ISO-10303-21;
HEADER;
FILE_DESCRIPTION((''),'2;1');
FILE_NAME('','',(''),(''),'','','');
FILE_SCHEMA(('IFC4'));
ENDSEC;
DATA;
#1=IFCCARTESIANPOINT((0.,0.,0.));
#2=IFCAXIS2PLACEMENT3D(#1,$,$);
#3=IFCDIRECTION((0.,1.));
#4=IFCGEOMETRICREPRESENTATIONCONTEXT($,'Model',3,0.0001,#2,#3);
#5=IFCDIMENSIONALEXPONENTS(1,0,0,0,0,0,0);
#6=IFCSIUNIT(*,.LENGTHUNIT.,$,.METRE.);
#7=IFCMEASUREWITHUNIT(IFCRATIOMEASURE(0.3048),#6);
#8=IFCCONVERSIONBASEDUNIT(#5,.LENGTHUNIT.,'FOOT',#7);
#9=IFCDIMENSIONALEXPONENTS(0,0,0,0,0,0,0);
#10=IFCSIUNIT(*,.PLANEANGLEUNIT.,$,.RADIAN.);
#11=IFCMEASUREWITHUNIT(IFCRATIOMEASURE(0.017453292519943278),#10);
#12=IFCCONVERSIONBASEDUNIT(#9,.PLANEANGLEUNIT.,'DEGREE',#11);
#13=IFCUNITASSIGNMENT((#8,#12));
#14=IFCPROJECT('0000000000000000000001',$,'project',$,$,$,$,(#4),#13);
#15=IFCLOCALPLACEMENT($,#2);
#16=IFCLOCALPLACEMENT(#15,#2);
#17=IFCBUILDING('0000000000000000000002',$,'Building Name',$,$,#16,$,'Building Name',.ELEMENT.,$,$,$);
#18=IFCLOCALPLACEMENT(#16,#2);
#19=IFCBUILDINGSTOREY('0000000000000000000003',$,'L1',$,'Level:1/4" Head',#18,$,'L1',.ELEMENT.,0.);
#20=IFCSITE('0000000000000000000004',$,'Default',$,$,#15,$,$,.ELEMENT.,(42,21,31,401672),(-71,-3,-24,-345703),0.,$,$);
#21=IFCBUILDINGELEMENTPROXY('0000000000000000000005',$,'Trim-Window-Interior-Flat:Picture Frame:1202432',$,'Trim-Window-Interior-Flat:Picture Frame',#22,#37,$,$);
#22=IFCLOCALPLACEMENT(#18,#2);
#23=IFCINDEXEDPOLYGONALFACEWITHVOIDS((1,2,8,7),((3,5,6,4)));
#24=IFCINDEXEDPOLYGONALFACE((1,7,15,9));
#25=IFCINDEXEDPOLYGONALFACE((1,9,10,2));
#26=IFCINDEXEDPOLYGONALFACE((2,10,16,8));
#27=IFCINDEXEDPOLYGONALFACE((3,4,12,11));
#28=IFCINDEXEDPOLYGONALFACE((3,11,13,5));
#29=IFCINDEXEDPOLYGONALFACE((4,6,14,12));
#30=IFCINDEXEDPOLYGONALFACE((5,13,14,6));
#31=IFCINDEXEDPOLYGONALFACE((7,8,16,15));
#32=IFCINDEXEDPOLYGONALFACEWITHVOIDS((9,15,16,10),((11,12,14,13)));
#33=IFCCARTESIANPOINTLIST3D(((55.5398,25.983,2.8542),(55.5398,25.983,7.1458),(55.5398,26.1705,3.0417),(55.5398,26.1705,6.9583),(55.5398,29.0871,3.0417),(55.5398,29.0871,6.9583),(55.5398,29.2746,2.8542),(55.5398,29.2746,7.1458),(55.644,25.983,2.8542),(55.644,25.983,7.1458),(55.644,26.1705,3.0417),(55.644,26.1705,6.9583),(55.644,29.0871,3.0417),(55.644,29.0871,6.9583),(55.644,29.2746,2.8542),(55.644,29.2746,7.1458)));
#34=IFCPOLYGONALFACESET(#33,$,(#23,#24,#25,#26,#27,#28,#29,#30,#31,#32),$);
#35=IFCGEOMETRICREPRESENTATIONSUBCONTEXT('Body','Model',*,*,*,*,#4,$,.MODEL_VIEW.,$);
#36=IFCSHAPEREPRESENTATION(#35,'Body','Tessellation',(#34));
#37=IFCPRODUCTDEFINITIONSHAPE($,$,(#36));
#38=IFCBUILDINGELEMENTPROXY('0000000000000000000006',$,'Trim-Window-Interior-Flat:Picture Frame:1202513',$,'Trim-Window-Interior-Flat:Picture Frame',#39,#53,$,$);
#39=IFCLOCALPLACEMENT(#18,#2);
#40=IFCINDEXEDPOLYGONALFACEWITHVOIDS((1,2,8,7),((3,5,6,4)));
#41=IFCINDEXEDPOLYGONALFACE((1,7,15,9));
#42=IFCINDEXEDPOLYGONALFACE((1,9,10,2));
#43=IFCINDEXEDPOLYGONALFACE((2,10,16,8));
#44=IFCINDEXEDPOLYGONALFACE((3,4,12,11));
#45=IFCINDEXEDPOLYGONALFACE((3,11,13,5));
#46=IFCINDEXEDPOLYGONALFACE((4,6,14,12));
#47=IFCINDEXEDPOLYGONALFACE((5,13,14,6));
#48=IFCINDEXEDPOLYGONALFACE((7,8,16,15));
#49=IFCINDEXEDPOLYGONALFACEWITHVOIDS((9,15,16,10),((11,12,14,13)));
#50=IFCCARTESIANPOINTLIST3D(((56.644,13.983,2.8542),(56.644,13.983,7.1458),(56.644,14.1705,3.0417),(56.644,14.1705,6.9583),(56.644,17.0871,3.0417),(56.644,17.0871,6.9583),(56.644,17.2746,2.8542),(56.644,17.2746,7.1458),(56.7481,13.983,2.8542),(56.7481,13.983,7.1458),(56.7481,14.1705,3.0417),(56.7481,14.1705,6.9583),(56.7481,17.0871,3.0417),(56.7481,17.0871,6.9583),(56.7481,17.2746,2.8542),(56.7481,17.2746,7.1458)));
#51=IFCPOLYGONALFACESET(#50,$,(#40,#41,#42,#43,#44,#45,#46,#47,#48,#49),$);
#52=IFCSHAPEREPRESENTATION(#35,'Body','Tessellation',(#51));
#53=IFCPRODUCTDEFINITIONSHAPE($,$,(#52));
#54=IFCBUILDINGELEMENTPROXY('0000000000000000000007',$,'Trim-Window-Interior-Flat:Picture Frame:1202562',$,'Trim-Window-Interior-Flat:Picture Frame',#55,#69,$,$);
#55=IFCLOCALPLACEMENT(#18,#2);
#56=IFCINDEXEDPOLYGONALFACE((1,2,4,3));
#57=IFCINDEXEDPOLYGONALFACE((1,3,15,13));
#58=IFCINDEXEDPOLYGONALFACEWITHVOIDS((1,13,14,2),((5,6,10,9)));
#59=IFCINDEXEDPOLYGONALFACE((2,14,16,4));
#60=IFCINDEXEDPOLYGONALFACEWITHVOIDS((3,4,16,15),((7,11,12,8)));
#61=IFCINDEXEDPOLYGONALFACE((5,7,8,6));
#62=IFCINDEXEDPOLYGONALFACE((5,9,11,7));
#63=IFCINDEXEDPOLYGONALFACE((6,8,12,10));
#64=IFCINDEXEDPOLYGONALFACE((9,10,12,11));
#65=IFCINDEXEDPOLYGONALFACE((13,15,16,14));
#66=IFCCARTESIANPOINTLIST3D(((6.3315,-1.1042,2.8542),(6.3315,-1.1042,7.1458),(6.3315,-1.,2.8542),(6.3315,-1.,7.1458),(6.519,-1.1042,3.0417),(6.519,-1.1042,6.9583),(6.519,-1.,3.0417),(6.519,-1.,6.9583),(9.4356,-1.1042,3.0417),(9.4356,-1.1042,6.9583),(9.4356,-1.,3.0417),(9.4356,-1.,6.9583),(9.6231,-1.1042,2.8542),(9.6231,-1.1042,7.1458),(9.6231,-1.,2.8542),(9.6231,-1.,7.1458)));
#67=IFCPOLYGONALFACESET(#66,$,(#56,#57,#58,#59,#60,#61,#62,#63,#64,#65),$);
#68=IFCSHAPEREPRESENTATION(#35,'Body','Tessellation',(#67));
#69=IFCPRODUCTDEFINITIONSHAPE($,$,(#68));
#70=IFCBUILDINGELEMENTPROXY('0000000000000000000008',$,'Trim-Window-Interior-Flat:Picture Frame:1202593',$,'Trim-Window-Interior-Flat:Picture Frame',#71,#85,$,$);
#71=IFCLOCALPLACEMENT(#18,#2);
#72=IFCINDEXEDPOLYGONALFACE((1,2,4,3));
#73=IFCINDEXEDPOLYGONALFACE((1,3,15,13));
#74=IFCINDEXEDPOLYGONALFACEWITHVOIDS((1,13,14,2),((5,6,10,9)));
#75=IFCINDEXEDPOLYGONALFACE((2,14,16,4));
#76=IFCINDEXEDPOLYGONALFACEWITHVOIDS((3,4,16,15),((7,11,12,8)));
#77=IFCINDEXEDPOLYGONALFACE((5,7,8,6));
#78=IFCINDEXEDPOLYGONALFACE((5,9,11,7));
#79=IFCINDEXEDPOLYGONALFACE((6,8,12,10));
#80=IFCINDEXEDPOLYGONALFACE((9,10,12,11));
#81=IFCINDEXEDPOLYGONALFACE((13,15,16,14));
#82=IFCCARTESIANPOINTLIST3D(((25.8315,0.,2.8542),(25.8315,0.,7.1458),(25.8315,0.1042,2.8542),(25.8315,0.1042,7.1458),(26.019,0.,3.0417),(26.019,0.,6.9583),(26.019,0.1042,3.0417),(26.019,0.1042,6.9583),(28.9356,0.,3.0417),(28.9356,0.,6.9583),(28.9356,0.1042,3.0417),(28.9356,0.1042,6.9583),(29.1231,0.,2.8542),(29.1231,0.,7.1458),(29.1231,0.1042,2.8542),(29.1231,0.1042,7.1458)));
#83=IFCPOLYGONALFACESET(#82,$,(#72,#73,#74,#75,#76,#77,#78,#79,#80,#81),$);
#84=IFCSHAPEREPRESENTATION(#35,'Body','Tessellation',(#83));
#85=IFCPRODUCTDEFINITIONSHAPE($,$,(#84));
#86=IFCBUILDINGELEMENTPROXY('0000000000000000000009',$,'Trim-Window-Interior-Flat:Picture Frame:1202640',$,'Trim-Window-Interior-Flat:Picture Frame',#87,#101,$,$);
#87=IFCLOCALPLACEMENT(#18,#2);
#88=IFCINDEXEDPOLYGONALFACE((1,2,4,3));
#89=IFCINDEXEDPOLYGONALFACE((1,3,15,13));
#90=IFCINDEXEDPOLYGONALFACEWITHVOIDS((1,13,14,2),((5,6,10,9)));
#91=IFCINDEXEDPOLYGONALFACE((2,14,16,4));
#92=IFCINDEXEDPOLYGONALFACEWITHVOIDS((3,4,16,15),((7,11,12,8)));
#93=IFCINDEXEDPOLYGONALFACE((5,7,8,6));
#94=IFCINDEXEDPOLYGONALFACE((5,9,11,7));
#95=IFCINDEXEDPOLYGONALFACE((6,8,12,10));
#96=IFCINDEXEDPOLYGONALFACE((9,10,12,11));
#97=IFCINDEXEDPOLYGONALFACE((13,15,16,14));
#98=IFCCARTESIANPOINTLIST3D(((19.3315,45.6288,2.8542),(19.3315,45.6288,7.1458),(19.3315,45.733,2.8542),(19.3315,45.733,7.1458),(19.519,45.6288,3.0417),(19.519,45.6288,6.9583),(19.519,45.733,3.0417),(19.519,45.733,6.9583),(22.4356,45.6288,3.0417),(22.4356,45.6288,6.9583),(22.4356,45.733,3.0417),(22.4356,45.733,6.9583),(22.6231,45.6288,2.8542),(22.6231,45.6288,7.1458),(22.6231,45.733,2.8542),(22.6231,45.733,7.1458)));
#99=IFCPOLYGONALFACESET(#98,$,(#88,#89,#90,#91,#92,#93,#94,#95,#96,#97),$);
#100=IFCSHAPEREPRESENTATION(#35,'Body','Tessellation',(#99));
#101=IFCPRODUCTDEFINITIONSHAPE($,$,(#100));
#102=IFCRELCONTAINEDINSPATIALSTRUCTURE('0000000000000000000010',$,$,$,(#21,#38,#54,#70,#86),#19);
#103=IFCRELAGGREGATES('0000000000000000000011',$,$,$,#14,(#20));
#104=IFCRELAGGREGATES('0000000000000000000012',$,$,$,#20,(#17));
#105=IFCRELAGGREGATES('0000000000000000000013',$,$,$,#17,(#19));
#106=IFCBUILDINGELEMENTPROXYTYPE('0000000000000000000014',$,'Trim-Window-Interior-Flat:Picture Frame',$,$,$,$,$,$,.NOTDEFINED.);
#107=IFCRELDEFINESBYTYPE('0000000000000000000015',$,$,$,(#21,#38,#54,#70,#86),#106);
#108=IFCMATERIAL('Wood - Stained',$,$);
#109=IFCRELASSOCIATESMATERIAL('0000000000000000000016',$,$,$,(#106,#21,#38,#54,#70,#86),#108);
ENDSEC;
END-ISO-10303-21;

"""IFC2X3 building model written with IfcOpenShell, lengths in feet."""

from ifc_helpers import new_model, entity, si_unit, converted_unit, direction, frame, origin, place, context, subcontext, project, spatial, polyline, outline, extrude, source, transform, mapped, material, type_object, type_shapes, element, save


model = new_model("IFC2X3")

# Units and contexts
model_context = context("Model", 3, precision=0.0001, world=origin(), true_north=direction((0.0, 1.0)))
body_context = subcontext(model_context, "Body", "Model", "MODEL_VIEW")
ifc_project = project(units=[converted_unit("LENGTHUNIT", "FOOT", entity("IfcRatioMeasure", 0.3048), si_unit("LENGTHUNIT", "METRE"), dimensions=[1, 0, 0, 0, 0, 0, 0]), converted_unit("PLANEANGLEUNIT", "DEGREE", entity("IfcRatioMeasure", 0.017453292519943278), si_unit("PLANEANGLEUNIT", "RADIAN"), dimensions=[0, 0, 0, 0, 0, 0, 0])], contexts=[model_context])

# Site, building, storey
site_placement = place(None, origin())
site = spatial("IfcSite", under=ifc_project, at=site_placement, Name="Default", CompositionType="ELEMENT", RefLatitude=(42, 21, 31, 401672), RefLongitude=(-71, -3, -24, -345703), RefElevation=0.0)
building_placement = place(site_placement, origin())
building = spatial("IfcBuilding", under=site, at=building_placement, Name="Building Name", LongName="Building Name", CompositionType="ELEMENT")
storey_placement = place(building_placement, origin())
storey = spatial("IfcBuildingStorey", under=building, at=storey_placement, Name="L1", ObjectType="Level:1/4\" Head", LongName="L1", CompositionType="ELEMENT", Elevation=0.0)

# Building element proxies
ifc_material_1 = material(Name="Wood - Stained")
building_element_proxy_type_1 = type_object("IfcBuildingElementProxyType", Name="Trim-Window-Interior-Flat:Picture Frame", PredefinedType="NOTDEFINED", material=ifc_material_1)
shared_shape_1 = source(origin(), body_context, "Body", "SweptSolid", [
    extrude(outline(polyline([(-1.6458, -2.1458), (1.6458, -2.1458), (1.6458, 2.1458), (-1.6458, 2.1458), (-1.6458, -2.1458)]), holes=[polyline([(-1.4583, -1.9583), (-1.4583, 1.9583), (1.4583, 1.9583), (1.4583, -1.9583), (-1.4583, -1.9583)])]), frame((0.0, -2.0, 0.0), z_axis=(0.0, 0.0, 1.0), x_axis=(-1.0, 0.0, 0.0)), (0.0, 0.0, 1.0), 0.1042),
])
type_shapes(building_element_proxy_type_1, [shared_shape_1])
for number, where, z_axis, x_axis, name in (
    (1, (55.644, 27.6288, 7.0), (-1.0, 0.0, 0.0), (0.0, -1.0, 0.0), "Trim-Window-Interior-Flat:Picture Frame:1202432"),
    (2, (56.644, 15.6288, 7.0), (1.0, 0.0, 0.0), (0.0, 1.0, 0.0), "Trim-Window-Interior-Flat:Picture Frame:1202513"),
    (3, (7.9773, -1.0, 7.0), (0.0, -1.0, 0.0), (1.0, 0.0, 0.0), "Trim-Window-Interior-Flat:Picture Frame:1202562"),
    (4, (27.4773, 0.0, 7.0), (0.0, 1.0, 0.0), (-1.0, 0.0, 0.0), "Trim-Window-Interior-Flat:Picture Frame:1202593"),
    (5, (20.9773, 45.6288, 7.0), (0.0, 1.0, 0.0), (-1.0, 0.0, 0.0), "Trim-Window-Interior-Flat:Picture Frame:1202640"),
):
    element("IfcBuildingElementProxy", number, at=place(storey_placement, frame(where, z_axis=z_axis, x_axis=x_axis)), inside=storey, type_object=building_element_proxy_type_1, material=ifc_material_1, Name=name, ObjectType="Trim-Window-Interior-Flat:Picture Frame", context=body_context, shape_type="MappedRepresentation", body=[
        mapped(shared_shape_1, transform((0.0, 0.0, 0.0), scale=1.0)),
    ])

save(model, "model.ifc")
